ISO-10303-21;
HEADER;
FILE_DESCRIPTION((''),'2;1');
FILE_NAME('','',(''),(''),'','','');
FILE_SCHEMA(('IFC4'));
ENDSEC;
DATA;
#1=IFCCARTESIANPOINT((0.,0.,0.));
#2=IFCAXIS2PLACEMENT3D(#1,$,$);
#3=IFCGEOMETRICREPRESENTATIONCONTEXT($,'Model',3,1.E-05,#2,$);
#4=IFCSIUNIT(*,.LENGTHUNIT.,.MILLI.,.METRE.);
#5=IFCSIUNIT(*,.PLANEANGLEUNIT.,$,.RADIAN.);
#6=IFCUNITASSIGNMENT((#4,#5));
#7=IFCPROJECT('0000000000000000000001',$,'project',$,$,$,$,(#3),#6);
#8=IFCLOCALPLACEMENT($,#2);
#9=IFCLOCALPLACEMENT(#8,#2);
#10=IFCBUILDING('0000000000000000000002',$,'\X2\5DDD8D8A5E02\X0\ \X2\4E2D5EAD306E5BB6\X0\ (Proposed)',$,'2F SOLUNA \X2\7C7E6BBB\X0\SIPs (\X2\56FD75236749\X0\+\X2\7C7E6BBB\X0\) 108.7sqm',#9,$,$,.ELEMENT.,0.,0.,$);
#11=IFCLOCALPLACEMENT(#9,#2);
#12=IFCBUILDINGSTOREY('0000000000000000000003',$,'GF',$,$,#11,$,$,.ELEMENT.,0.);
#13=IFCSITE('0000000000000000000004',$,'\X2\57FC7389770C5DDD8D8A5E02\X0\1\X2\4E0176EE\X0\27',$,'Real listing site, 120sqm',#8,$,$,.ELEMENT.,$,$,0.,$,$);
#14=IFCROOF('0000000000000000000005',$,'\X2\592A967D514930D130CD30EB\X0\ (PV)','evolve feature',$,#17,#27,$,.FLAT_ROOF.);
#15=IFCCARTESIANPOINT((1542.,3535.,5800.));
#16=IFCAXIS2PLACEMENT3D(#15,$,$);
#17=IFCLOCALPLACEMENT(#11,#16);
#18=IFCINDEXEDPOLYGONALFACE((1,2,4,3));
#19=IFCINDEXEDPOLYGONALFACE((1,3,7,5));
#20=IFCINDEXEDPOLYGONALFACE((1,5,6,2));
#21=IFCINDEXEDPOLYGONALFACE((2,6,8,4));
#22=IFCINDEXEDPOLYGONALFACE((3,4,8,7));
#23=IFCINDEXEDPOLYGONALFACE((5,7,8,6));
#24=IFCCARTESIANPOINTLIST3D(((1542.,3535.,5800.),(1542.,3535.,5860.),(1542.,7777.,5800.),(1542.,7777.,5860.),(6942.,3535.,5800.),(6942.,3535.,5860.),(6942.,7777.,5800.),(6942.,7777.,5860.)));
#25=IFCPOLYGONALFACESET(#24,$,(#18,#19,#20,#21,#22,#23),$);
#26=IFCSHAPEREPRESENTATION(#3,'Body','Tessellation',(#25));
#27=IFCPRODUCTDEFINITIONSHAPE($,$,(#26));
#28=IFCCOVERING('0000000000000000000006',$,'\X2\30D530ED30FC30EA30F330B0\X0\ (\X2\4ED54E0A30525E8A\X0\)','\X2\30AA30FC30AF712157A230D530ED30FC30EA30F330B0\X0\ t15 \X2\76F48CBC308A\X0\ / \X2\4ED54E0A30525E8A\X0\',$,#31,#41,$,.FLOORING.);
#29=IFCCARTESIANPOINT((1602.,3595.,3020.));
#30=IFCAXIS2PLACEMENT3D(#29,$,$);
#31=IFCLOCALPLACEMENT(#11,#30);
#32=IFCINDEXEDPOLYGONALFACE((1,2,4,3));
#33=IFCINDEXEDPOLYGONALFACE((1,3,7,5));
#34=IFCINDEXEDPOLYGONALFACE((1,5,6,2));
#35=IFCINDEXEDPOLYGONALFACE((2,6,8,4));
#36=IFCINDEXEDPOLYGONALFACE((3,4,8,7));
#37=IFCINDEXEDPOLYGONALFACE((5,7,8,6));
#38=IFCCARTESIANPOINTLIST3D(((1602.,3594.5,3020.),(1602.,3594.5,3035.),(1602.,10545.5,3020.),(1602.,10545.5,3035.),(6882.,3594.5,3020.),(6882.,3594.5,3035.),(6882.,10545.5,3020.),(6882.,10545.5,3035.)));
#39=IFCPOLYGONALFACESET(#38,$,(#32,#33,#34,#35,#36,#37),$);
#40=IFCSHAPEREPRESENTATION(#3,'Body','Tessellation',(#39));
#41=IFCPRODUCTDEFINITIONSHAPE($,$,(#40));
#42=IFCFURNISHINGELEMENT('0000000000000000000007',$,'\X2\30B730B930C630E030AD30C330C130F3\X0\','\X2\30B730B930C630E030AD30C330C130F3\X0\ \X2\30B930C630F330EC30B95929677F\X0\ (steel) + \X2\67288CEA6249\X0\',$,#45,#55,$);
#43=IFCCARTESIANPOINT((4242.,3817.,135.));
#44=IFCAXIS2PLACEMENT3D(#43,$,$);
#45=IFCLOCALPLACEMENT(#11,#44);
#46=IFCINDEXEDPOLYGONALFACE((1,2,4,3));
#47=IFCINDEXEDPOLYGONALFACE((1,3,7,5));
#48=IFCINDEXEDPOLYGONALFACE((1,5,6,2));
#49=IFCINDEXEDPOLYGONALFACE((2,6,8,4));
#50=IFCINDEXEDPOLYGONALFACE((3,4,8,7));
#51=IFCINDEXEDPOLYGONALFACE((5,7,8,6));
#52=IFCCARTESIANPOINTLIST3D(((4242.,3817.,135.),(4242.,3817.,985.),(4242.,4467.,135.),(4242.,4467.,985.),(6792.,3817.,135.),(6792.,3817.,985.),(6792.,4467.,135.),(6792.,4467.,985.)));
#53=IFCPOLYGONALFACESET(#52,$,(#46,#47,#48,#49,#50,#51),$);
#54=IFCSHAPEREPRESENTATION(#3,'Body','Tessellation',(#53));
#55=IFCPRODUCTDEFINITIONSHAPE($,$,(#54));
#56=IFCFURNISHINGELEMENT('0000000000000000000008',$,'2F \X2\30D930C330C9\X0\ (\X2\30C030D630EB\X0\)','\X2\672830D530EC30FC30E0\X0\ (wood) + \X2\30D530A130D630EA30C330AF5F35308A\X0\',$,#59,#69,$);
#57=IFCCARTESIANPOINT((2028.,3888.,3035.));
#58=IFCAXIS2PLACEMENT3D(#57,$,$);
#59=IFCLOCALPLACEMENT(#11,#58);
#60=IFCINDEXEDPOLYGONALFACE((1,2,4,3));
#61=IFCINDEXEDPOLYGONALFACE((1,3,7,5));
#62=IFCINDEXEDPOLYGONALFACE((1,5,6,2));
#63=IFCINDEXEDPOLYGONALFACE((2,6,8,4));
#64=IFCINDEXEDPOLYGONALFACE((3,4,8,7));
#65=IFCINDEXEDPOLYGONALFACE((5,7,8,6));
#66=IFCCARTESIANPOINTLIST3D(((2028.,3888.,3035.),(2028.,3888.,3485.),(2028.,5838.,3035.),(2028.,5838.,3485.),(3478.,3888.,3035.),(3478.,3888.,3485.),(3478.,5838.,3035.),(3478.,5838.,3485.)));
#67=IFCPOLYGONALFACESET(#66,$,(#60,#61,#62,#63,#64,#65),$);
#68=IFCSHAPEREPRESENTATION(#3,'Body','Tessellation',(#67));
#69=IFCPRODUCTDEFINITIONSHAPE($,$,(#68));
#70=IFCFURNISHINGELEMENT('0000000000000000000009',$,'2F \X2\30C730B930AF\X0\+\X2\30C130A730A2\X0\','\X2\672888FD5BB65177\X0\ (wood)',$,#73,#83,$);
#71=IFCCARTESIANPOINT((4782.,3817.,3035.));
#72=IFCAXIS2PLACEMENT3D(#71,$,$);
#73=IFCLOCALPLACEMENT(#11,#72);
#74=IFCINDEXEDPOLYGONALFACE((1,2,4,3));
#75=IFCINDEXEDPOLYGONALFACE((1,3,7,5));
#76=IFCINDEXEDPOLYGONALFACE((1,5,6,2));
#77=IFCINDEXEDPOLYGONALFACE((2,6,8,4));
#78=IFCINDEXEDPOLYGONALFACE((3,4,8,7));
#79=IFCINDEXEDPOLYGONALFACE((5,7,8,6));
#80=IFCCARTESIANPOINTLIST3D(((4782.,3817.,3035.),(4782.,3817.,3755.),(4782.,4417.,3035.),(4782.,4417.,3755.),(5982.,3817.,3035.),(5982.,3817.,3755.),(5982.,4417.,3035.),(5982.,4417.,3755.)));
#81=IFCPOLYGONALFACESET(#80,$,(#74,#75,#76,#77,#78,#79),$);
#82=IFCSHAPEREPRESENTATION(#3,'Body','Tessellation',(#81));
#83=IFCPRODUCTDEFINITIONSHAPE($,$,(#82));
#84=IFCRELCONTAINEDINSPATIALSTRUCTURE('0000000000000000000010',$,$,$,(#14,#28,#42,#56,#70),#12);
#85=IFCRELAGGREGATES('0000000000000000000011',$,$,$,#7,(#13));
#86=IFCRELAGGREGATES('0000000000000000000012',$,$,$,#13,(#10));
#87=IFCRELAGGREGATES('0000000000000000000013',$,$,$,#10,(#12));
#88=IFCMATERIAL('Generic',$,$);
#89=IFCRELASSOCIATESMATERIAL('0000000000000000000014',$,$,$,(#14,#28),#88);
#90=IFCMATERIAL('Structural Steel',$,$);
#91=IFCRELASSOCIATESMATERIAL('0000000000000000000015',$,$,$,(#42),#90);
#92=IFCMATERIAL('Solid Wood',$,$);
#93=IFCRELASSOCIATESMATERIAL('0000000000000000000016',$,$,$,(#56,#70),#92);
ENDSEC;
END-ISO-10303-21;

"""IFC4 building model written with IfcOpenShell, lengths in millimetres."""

from ifc_helpers import new_model, si_unit, frame, frame_2d, origin, place, context, project, spatial, rectangle, extrude, material, element, save


model = new_model("IFC4")

# Units and contexts
model_context = context("Model", 3, precision=1e-05, world=origin())
ifc_project = project(units=[si_unit("LENGTHUNIT", "METRE", prefix="MILLI"), si_unit("PLANEANGLEUNIT", "RADIAN")], contexts=[model_context])

# Site, building, storey
site_placement = place(None, origin())
site = spatial("IfcSite", under=ifc_project, at=site_placement, Name="埼玉県川越市1丁目27", ObjectType="Real listing site, 120sqm", CompositionType="ELEMENT", RefElevation=0.0)
building_placement = place(site_placement, origin())
building = spatial("IfcBuilding", under=site, at=building_placement, Name="川越市 中庭の家 (Proposed)", ObjectType="2F SOLUNA 籾殻SIPs (国産杉+籾殻) 108.7sqm", CompositionType="ELEMENT", ElevationOfRefHeight=0.0, ElevationOfTerrain=0.0)
storey_placement = place(building_placement, origin())
storey = spatial("IfcBuildingStorey", under=building, at=storey_placement, Name="GF", CompositionType="ELEMENT", Elevation=0.0)

# Shared definitions
ifc_material_1 = material(Name="Solid Wood")

# Shared definitions
ifc_material_2 = material(Name="Generic")

# Roof
ifc_material_3 = material(Name="Structural Steel")
roof_1_placement = place(storey_placement, frame((1542.0, 3535.0, 5800.0)))
element("IfcRoof", 1, at=roof_1_placement, inside=storey, material=ifc_material_2, Name="太陽光パネル (PV)", Description="evolve feature", PredefinedType="FLAT_ROOF", context=model_context, shape_type="SweptSolid", body=[
    extrude(rectangle(XDim=5400.0, YDim=4242.0, at=frame_2d((2700.0, 2121.0))), frame((1542.0, 3535.0, 5800.0)), (0.0, 0.0, 1.0), 60.0),
])

# Covering
covering_placement = place(storey_placement, frame((1602.0, 3595.0, 3020.0)))
element("IfcCovering", 2, at=covering_placement, inside=storey, material=ifc_material_2, Name="フローリング (仕上げ床)", Description="オーク無垢フローリング t15 直貼り / 仕上げ床", PredefinedType="FLOORING", context=model_context, shape_type="SweptSolid", body=[
    extrude(rectangle(XDim=5280.0, YDim=6951.0, at=frame_2d((2640.0, 3475.0))), frame((1602.0, 3595.0, 3020.0)), (0.0, 0.0, 1.0), 15.0),
])

# Furnishing elements
furnishing_1_placement = place(storey_placement, frame((4242.0, 3817.0, 135.0)))
element("IfcFurnishingElement", 3, at=furnishing_1_placement, inside=storey, material=ifc_material_3, Name="システムキッチン", Description="システムキッチン ステンレス天板 (steel) + 木質扉", context=model_context, shape_type="SweptSolid", body=[
    extrude(rectangle(XDim=2550.0, YDim=650.0, at=frame_2d((1275.0, 325.0))), frame((4242.0, 3817.0, 135.0)), (0.0, 0.0, 1.0), 850.0),
])
furnishing_2_placement = place(storey_placement, frame((2028.0, 3888.0, 3035.0)))
element("IfcFurnishingElement", 4, at=furnishing_2_placement, inside=storey, material=ifc_material_1, Name="2F ベッド (ダブル)", Description="木フレーム (wood) + ファブリック張り", context=model_context, shape_type="SweptSolid", body=[
    extrude(rectangle(XDim=1450.0, YDim=1950.0, at=frame_2d((725.0, 975.0))), frame((2028.0, 3888.0, 3035.0)), (0.0, 0.0, 1.0), 450.0),
])
furnishing_3_placement = place(storey_placement, frame((4782.0, 3817.0, 3035.0)))
element("IfcFurnishingElement", 5, at=furnishing_3_placement, inside=storey, material=ifc_material_1, Name="2F デスク+チェア", Description="木製家具 (wood)", context=model_context, shape_type="SweptSolid", body=[
    extrude(rectangle(XDim=1200.0, YDim=600.0, at=frame_2d((600.0, 300.0))), frame((4782.0, 3817.0, 3035.0)), (0.0, 0.0, 1.0), 720.0),
])

save(model, "model.ifc")
